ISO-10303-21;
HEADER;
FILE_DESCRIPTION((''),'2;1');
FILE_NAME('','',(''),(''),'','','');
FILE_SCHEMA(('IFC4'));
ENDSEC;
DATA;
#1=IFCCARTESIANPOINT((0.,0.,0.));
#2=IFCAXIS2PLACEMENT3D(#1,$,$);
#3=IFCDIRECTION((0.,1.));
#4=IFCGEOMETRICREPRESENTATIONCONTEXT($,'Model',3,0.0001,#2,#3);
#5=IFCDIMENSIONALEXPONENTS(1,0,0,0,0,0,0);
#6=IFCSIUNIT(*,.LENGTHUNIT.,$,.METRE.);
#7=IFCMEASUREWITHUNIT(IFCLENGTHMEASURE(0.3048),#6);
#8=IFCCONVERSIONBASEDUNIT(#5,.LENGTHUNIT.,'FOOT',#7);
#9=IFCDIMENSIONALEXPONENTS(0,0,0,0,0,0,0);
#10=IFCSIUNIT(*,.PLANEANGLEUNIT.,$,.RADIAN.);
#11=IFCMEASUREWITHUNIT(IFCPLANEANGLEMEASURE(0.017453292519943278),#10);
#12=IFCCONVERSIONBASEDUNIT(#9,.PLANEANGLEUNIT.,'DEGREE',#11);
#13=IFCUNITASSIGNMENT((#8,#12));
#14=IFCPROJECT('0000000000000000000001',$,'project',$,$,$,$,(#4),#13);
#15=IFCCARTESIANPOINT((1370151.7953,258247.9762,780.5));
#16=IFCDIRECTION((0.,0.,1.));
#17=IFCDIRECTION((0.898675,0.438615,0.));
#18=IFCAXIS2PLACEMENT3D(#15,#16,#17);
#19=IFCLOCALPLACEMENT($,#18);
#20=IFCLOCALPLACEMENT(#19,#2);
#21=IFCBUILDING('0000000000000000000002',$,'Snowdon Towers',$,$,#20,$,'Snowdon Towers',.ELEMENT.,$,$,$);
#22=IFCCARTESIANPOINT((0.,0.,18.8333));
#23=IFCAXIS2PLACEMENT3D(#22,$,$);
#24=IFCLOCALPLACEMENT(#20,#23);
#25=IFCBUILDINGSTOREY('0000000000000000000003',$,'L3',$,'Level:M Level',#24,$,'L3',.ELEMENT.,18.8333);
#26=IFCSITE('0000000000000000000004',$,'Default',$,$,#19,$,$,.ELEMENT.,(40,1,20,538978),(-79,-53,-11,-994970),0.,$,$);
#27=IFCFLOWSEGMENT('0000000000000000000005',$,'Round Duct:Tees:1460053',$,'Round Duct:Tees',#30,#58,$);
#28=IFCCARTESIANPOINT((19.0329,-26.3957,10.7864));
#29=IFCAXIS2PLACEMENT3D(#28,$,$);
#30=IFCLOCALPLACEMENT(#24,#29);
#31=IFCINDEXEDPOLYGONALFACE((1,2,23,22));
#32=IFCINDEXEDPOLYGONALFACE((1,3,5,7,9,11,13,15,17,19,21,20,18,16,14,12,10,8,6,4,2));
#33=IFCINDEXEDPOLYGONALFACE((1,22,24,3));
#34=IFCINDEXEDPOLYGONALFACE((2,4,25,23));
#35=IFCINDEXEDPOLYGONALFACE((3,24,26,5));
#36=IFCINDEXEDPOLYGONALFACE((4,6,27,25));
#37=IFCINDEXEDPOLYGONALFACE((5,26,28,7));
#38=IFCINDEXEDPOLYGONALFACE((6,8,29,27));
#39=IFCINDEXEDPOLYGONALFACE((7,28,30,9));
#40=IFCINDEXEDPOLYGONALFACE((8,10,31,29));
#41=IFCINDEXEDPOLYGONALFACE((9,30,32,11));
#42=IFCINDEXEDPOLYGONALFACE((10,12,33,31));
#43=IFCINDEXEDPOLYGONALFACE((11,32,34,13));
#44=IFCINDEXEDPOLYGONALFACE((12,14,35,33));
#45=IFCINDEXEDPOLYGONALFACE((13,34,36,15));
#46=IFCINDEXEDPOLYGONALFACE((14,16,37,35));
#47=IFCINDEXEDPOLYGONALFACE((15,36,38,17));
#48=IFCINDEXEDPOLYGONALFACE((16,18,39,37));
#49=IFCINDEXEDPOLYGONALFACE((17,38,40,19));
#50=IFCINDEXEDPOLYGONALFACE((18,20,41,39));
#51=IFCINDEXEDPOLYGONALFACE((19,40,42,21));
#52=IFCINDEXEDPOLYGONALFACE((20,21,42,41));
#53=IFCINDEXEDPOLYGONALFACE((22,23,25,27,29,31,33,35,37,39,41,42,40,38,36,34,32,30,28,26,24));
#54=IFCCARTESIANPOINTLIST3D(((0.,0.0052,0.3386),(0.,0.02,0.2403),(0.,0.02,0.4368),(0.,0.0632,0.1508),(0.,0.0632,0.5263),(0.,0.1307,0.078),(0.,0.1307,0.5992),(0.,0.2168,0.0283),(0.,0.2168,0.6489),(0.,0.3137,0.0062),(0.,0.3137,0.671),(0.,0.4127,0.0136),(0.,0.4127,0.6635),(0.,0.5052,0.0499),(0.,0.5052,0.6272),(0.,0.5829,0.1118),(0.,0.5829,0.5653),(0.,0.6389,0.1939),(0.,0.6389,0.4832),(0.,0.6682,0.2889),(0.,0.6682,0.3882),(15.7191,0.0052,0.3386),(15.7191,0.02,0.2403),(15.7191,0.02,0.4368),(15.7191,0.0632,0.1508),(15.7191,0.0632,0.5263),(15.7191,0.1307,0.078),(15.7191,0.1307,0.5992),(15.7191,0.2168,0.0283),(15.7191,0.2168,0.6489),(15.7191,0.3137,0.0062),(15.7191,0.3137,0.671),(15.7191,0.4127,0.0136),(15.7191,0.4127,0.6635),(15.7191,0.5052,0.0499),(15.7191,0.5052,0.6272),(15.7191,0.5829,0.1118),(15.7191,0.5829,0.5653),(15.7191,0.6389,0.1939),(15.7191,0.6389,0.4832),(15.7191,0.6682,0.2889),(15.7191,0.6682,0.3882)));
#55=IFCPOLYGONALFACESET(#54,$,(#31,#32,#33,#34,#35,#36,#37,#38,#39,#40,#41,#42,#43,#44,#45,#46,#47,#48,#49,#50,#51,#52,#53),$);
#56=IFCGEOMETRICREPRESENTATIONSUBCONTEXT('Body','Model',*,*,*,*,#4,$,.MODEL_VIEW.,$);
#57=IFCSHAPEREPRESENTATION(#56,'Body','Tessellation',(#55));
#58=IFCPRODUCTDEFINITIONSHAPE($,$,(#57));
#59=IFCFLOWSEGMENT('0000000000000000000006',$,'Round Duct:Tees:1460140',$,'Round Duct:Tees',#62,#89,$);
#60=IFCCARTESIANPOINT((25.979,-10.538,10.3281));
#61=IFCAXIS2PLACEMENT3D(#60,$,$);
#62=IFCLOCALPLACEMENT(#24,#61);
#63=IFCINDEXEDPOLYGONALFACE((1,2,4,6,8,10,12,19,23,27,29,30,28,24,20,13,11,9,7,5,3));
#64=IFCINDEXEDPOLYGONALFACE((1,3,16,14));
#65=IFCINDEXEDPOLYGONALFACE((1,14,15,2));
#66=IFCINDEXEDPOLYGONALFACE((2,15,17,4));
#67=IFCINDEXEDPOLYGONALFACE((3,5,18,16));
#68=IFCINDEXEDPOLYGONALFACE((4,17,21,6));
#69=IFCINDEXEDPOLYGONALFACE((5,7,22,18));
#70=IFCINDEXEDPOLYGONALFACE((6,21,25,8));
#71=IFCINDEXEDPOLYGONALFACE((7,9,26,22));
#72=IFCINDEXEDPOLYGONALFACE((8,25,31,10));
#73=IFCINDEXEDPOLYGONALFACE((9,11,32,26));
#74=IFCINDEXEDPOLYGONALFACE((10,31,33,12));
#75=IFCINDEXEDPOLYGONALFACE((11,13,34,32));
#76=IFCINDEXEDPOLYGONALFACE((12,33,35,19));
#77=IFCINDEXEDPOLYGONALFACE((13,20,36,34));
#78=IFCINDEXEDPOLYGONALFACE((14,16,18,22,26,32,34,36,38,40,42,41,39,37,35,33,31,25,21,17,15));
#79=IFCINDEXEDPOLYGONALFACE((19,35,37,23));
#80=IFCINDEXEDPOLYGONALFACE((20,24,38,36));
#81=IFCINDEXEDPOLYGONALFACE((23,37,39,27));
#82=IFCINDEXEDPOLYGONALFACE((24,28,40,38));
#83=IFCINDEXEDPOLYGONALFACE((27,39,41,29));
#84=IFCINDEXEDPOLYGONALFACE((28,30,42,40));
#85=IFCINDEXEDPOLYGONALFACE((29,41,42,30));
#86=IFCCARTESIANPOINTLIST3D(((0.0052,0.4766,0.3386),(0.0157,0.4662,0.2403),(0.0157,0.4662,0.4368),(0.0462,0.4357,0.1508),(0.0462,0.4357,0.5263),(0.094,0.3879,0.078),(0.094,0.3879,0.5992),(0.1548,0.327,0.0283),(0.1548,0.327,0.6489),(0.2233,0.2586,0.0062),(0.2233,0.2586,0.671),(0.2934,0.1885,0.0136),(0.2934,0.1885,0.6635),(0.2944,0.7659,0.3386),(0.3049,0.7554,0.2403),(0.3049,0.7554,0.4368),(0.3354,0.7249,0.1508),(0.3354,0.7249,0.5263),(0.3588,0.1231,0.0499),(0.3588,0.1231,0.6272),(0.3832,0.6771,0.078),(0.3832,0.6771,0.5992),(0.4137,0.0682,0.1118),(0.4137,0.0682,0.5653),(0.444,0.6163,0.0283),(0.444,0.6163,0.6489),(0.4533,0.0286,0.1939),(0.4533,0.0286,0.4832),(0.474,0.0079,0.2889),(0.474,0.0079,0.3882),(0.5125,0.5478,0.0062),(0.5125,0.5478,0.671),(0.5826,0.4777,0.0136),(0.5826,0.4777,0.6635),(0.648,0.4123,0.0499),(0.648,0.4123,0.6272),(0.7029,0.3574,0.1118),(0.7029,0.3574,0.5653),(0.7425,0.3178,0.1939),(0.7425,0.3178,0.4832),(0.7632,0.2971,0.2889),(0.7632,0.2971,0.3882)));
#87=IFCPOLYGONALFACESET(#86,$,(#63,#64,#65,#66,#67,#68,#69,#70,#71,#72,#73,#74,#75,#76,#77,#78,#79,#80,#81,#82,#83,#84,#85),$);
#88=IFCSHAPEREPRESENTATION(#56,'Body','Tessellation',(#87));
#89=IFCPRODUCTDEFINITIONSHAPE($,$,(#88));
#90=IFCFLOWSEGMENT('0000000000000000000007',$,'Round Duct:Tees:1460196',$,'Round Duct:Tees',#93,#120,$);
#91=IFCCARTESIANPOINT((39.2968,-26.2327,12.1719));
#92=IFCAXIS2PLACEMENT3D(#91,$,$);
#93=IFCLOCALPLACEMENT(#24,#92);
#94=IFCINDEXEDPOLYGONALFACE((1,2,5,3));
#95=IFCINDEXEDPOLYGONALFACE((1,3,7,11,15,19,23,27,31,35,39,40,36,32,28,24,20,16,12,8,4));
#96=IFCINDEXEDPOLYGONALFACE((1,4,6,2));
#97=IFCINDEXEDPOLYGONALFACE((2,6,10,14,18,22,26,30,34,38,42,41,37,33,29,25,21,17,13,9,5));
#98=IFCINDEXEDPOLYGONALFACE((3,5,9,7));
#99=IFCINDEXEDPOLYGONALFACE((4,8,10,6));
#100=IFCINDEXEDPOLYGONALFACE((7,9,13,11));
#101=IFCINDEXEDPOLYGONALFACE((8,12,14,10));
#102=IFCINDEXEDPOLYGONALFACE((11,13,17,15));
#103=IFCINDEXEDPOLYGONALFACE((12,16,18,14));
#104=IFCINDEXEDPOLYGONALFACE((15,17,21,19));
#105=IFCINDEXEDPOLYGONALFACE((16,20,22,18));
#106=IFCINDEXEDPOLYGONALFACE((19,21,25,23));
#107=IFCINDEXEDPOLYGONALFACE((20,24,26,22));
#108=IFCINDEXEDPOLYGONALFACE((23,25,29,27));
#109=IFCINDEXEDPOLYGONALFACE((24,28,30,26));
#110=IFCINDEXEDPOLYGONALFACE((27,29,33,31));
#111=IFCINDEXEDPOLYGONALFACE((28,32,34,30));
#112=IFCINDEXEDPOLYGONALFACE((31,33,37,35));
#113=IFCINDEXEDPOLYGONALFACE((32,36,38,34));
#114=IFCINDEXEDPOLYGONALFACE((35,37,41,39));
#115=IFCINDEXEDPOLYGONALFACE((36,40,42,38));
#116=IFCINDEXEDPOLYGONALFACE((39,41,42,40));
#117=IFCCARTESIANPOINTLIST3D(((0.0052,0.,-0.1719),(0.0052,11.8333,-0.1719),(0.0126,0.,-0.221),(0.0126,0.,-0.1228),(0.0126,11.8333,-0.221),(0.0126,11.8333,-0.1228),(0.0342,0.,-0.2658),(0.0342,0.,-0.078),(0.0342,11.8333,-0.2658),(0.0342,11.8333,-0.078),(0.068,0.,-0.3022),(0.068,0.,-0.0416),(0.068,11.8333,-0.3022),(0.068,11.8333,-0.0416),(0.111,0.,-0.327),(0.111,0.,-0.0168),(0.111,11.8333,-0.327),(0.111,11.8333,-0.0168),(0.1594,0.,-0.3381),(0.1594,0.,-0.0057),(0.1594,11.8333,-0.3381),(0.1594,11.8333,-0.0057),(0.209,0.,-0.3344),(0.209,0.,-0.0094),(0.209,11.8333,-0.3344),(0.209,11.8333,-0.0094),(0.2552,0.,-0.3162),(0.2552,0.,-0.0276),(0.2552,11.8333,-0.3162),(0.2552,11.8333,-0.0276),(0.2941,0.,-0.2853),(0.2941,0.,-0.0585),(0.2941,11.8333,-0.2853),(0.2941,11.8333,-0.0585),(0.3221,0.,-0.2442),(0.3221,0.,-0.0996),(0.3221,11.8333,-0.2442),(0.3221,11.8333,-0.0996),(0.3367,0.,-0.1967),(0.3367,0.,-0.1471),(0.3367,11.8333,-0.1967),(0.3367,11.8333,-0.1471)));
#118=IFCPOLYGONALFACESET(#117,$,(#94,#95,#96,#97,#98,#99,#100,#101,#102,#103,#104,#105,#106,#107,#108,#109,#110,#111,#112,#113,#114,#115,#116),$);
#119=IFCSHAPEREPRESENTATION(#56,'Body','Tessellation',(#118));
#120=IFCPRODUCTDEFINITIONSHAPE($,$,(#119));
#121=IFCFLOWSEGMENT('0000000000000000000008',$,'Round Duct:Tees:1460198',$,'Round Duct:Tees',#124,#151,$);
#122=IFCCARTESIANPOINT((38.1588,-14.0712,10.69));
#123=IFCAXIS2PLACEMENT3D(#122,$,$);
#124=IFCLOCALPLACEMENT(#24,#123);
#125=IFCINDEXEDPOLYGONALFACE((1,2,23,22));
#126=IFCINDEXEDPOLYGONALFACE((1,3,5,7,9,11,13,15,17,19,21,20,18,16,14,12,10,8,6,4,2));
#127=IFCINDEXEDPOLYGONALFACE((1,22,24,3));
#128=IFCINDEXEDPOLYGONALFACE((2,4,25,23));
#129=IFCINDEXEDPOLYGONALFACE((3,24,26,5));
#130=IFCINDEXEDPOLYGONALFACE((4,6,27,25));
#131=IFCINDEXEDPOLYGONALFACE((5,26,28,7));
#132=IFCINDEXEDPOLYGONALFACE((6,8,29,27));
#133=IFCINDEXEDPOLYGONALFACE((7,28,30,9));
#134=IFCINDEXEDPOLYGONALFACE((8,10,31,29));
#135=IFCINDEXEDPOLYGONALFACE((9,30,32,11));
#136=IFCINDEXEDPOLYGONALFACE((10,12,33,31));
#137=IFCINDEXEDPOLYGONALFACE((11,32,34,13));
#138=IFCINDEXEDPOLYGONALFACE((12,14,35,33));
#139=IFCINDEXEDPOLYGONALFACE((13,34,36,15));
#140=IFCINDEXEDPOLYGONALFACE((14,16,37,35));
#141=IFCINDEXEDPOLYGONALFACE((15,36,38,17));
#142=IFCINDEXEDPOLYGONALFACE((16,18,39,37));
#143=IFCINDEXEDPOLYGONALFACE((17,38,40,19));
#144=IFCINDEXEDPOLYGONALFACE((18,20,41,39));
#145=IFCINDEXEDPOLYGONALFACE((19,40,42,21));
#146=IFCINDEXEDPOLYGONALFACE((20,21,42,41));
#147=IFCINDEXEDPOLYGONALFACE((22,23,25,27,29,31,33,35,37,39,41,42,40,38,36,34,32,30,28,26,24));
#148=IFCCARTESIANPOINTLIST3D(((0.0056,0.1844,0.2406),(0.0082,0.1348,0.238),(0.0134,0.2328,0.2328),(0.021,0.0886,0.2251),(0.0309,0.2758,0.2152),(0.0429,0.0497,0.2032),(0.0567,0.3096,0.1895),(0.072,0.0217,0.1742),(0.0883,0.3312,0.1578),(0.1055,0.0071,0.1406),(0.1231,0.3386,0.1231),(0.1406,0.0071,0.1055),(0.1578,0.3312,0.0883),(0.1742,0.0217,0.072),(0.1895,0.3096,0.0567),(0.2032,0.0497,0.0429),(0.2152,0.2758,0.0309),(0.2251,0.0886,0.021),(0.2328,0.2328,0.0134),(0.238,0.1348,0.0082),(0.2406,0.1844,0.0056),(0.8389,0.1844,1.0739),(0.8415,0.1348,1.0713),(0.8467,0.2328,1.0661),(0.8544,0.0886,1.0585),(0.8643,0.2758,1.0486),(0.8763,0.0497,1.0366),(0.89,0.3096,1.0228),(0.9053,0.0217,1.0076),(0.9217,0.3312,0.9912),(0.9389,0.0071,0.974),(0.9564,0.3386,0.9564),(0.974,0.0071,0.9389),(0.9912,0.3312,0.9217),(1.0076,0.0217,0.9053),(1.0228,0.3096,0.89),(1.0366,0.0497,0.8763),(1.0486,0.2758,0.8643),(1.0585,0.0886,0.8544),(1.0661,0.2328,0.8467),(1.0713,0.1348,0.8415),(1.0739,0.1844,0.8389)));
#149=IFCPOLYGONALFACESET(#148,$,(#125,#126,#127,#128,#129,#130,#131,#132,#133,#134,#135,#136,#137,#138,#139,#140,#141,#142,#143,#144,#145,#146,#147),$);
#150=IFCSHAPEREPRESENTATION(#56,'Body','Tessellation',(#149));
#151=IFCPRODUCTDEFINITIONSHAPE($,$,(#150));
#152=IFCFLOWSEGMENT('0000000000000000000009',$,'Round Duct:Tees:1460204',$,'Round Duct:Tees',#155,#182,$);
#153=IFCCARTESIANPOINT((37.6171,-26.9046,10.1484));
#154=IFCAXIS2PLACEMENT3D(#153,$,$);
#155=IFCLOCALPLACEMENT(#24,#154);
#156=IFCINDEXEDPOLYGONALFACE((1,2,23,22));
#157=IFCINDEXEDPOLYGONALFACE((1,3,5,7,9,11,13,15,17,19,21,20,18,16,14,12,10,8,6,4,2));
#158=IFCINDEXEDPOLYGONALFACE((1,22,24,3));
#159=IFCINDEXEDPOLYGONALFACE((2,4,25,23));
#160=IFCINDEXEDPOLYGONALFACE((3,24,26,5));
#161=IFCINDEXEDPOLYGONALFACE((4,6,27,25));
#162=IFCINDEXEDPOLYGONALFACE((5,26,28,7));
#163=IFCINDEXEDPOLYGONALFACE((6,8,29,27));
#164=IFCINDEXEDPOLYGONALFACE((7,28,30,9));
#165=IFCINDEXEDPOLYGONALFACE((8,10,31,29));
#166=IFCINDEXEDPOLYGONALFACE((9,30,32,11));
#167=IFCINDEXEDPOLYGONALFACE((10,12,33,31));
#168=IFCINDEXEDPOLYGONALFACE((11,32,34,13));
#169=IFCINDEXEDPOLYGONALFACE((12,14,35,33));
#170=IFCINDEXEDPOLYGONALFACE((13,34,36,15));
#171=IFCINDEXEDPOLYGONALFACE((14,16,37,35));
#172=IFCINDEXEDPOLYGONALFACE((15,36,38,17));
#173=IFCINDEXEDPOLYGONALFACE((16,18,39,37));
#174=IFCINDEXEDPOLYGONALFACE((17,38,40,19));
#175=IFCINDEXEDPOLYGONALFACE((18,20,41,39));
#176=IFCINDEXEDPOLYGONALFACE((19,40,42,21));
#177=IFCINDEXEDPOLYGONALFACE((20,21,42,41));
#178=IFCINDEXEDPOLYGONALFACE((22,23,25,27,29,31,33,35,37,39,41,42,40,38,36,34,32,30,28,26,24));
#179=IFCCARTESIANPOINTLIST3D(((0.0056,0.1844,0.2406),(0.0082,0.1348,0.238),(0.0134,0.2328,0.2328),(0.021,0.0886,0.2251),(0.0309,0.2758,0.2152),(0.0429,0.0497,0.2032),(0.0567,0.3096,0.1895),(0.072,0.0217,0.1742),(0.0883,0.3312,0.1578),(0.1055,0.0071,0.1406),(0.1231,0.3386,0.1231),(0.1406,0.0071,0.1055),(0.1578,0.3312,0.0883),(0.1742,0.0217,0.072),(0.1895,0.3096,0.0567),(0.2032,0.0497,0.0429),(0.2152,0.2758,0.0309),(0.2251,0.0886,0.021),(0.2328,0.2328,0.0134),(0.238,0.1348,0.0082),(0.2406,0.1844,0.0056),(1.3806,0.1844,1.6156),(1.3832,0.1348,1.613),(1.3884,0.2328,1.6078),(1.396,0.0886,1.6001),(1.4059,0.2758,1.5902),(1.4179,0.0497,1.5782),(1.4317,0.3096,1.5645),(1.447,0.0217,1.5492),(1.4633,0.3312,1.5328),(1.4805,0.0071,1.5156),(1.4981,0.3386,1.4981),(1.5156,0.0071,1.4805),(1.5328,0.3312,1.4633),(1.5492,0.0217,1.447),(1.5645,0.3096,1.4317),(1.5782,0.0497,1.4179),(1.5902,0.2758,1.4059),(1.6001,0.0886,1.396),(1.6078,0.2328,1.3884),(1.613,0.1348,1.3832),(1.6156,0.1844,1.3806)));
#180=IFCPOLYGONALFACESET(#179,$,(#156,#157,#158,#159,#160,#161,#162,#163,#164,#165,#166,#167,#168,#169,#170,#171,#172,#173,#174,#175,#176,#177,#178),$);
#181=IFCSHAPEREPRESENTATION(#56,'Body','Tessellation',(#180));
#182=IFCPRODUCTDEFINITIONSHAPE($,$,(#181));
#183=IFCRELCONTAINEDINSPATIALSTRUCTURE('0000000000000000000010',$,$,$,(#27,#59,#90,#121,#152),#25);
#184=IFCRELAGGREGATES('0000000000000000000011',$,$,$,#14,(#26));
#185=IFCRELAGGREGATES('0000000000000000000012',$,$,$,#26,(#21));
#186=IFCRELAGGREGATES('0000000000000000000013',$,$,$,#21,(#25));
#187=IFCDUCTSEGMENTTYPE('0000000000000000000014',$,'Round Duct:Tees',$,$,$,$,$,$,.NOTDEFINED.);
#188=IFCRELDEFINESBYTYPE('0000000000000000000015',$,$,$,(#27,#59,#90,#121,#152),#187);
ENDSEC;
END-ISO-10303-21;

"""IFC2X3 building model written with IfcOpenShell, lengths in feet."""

from ifc_helpers import new_model, entity, si_unit, converted_unit, direction, frame, frame_2d, origin, origin_2d_with_axis, place, context, subcontext, project, spatial, circle, extrude, type_object, element, save


model = new_model("IFC2X3")

# Units and contexts
model_context = context("Model", 3, precision=0.0001, world=origin(), true_north=direction((0.0, 1.0)))
body_context = subcontext(model_context, "Body", "Model", "MODEL_VIEW")
ifc_project = project(units=[converted_unit("LENGTHUNIT", "FOOT", entity("IfcLengthMeasure", 0.3048), si_unit("LENGTHUNIT", "METRE"), dimensions=[1, 0, 0, 0, 0, 0, 0]), converted_unit("PLANEANGLEUNIT", "DEGREE", entity("IfcPlaneAngleMeasure", 0.017453292519943278), si_unit("PLANEANGLEUNIT", "RADIAN"), dimensions=[0, 0, 0, 0, 0, 0, 0])], contexts=[model_context])

# Site, building, storey
site_placement = place(None, frame((1370151.7953, 258247.9762, 780.5), z_axis=(0.0, 0.0, 1.0), x_axis=(0.898675, 0.438615, 0.0)))
site = spatial("IfcSite", under=ifc_project, at=site_placement, Name="Default", CompositionType="ELEMENT", RefLatitude=(40, 1, 20, 538978), RefLongitude=(-79, -53, -11, -994970), RefElevation=0.0)
building_placement = place(site_placement, origin())
building = spatial("IfcBuilding", under=site, at=building_placement, Name="Snowdon Towers", LongName="Snowdon Towers", CompositionType="ELEMENT")
storey_placement = place(building_placement, frame((0.0, 0.0, 18.8333)))
storey = spatial("IfcBuildingStorey", under=building, at=storey_placement, Name="L3", ObjectType="Level:M Level", LongName="L3", CompositionType="ELEMENT", Elevation=18.8333)

# Flow segments
duct_segment_type = type_object("IfcDuctSegmentType", Name="Round Duct:Tees", PredefinedType="NOTDEFINED")
flow_segment_1_placement = place(storey_placement, frame((19.0329, -26.3957, 10.7864)))
element("IfcFlowSegment", 1, at=flow_segment_1_placement, inside=storey, type_object=duct_segment_type, Name="Round Duct:Tees:1460053", ObjectType="Round Duct:Tees", context=body_context, shape_type="SweptSolid", body=[
    extrude(circle(Radius=0.3333, at=frame_2d((0.0, 0.0), x_axis=(1.0, 0.0))), frame((0.0, 0.3386, 0.3386), z_axis=(1.0, 0.0, 0.0), x_axis=(0.0, -1.0, 0.0)), (0.0, 0.0, 1.0), 15.7191),
])
flow_segment_2_placement = place(storey_placement, frame((25.979, -10.538, 10.3281)))
element("IfcFlowSegment", 2, at=flow_segment_2_placement, inside=storey, type_object=duct_segment_type, Name="Round Duct:Tees:1460140", ObjectType="Round Duct:Tees", context=body_context, shape_type="SweptSolid", body=[
    extrude(circle(Radius=0.3333, at=origin_2d_with_axis()), frame((0.2409, 0.2409, 0.3386), z_axis=(0.707107, 0.707107, 0.0), x_axis=(-0.707107, 0.707107, 0.0)), (0.0, 0.0, 1.0), 0.409),
])
flow_segment_3_placement = place(storey_placement, frame((39.2968, -26.2327, 12.1719)))
element("IfcFlowSegment", 3, at=flow_segment_3_placement, inside=storey, type_object=duct_segment_type, Name="Round Duct:Tees:1460196", ObjectType="Round Duct:Tees", context=body_context, shape_type="SweptSolid", body=[
    extrude(circle(Radius=0.1667, at=frame_2d((0.0, 0.0), x_axis=(1.0, 0.0))), frame((0.1719, 0.0, -0.1719), z_axis=(0.0, 1.0, 0.0), x_axis=(-1.0, 0.0, 0.0)), (0.0, 0.0, 1.0), 11.8333),
])
flow_segment_4_placement = place(storey_placement, frame((38.1588, -14.0712, 10.69)))
element("IfcFlowSegment", 4, at=flow_segment_4_placement, inside=storey, type_object=duct_segment_type, Name="Round Duct:Tees:1460198", ObjectType="Round Duct:Tees", context=body_context, shape_type="SweptSolid", body=[
    extrude(circle(Radius=0.1667, at=frame_2d((0.0, 0.0), x_axis=(1.0, 0.0))), frame((0.1231, 0.1719, 0.1231), z_axis=(0.707107, 0.0, 0.707107), x_axis=(0.0, 1.0, 0.0)), (0.0, 0.0, 1.0), 1.1785),
])
flow_segment_5_placement = place(storey_placement, frame((37.6171, -26.9046, 10.1484)))
element("IfcFlowSegment", 5, at=flow_segment_5_placement, inside=storey, type_object=duct_segment_type, Name="Round Duct:Tees:1460204", ObjectType="Round Duct:Tees", context=body_context, shape_type="SweptSolid", body=[
    extrude(circle(Radius=0.1667, at=frame_2d((0.0, 0.0), x_axis=(1.0, 0.0))), frame((0.1231, 0.1719, 0.1231), z_axis=(0.707107, 0.0, 0.707107), x_axis=(0.0, 1.0, 0.0)), (0.0, 0.0, 1.0), 1.9445),
])

save(model, "model.ifc")
